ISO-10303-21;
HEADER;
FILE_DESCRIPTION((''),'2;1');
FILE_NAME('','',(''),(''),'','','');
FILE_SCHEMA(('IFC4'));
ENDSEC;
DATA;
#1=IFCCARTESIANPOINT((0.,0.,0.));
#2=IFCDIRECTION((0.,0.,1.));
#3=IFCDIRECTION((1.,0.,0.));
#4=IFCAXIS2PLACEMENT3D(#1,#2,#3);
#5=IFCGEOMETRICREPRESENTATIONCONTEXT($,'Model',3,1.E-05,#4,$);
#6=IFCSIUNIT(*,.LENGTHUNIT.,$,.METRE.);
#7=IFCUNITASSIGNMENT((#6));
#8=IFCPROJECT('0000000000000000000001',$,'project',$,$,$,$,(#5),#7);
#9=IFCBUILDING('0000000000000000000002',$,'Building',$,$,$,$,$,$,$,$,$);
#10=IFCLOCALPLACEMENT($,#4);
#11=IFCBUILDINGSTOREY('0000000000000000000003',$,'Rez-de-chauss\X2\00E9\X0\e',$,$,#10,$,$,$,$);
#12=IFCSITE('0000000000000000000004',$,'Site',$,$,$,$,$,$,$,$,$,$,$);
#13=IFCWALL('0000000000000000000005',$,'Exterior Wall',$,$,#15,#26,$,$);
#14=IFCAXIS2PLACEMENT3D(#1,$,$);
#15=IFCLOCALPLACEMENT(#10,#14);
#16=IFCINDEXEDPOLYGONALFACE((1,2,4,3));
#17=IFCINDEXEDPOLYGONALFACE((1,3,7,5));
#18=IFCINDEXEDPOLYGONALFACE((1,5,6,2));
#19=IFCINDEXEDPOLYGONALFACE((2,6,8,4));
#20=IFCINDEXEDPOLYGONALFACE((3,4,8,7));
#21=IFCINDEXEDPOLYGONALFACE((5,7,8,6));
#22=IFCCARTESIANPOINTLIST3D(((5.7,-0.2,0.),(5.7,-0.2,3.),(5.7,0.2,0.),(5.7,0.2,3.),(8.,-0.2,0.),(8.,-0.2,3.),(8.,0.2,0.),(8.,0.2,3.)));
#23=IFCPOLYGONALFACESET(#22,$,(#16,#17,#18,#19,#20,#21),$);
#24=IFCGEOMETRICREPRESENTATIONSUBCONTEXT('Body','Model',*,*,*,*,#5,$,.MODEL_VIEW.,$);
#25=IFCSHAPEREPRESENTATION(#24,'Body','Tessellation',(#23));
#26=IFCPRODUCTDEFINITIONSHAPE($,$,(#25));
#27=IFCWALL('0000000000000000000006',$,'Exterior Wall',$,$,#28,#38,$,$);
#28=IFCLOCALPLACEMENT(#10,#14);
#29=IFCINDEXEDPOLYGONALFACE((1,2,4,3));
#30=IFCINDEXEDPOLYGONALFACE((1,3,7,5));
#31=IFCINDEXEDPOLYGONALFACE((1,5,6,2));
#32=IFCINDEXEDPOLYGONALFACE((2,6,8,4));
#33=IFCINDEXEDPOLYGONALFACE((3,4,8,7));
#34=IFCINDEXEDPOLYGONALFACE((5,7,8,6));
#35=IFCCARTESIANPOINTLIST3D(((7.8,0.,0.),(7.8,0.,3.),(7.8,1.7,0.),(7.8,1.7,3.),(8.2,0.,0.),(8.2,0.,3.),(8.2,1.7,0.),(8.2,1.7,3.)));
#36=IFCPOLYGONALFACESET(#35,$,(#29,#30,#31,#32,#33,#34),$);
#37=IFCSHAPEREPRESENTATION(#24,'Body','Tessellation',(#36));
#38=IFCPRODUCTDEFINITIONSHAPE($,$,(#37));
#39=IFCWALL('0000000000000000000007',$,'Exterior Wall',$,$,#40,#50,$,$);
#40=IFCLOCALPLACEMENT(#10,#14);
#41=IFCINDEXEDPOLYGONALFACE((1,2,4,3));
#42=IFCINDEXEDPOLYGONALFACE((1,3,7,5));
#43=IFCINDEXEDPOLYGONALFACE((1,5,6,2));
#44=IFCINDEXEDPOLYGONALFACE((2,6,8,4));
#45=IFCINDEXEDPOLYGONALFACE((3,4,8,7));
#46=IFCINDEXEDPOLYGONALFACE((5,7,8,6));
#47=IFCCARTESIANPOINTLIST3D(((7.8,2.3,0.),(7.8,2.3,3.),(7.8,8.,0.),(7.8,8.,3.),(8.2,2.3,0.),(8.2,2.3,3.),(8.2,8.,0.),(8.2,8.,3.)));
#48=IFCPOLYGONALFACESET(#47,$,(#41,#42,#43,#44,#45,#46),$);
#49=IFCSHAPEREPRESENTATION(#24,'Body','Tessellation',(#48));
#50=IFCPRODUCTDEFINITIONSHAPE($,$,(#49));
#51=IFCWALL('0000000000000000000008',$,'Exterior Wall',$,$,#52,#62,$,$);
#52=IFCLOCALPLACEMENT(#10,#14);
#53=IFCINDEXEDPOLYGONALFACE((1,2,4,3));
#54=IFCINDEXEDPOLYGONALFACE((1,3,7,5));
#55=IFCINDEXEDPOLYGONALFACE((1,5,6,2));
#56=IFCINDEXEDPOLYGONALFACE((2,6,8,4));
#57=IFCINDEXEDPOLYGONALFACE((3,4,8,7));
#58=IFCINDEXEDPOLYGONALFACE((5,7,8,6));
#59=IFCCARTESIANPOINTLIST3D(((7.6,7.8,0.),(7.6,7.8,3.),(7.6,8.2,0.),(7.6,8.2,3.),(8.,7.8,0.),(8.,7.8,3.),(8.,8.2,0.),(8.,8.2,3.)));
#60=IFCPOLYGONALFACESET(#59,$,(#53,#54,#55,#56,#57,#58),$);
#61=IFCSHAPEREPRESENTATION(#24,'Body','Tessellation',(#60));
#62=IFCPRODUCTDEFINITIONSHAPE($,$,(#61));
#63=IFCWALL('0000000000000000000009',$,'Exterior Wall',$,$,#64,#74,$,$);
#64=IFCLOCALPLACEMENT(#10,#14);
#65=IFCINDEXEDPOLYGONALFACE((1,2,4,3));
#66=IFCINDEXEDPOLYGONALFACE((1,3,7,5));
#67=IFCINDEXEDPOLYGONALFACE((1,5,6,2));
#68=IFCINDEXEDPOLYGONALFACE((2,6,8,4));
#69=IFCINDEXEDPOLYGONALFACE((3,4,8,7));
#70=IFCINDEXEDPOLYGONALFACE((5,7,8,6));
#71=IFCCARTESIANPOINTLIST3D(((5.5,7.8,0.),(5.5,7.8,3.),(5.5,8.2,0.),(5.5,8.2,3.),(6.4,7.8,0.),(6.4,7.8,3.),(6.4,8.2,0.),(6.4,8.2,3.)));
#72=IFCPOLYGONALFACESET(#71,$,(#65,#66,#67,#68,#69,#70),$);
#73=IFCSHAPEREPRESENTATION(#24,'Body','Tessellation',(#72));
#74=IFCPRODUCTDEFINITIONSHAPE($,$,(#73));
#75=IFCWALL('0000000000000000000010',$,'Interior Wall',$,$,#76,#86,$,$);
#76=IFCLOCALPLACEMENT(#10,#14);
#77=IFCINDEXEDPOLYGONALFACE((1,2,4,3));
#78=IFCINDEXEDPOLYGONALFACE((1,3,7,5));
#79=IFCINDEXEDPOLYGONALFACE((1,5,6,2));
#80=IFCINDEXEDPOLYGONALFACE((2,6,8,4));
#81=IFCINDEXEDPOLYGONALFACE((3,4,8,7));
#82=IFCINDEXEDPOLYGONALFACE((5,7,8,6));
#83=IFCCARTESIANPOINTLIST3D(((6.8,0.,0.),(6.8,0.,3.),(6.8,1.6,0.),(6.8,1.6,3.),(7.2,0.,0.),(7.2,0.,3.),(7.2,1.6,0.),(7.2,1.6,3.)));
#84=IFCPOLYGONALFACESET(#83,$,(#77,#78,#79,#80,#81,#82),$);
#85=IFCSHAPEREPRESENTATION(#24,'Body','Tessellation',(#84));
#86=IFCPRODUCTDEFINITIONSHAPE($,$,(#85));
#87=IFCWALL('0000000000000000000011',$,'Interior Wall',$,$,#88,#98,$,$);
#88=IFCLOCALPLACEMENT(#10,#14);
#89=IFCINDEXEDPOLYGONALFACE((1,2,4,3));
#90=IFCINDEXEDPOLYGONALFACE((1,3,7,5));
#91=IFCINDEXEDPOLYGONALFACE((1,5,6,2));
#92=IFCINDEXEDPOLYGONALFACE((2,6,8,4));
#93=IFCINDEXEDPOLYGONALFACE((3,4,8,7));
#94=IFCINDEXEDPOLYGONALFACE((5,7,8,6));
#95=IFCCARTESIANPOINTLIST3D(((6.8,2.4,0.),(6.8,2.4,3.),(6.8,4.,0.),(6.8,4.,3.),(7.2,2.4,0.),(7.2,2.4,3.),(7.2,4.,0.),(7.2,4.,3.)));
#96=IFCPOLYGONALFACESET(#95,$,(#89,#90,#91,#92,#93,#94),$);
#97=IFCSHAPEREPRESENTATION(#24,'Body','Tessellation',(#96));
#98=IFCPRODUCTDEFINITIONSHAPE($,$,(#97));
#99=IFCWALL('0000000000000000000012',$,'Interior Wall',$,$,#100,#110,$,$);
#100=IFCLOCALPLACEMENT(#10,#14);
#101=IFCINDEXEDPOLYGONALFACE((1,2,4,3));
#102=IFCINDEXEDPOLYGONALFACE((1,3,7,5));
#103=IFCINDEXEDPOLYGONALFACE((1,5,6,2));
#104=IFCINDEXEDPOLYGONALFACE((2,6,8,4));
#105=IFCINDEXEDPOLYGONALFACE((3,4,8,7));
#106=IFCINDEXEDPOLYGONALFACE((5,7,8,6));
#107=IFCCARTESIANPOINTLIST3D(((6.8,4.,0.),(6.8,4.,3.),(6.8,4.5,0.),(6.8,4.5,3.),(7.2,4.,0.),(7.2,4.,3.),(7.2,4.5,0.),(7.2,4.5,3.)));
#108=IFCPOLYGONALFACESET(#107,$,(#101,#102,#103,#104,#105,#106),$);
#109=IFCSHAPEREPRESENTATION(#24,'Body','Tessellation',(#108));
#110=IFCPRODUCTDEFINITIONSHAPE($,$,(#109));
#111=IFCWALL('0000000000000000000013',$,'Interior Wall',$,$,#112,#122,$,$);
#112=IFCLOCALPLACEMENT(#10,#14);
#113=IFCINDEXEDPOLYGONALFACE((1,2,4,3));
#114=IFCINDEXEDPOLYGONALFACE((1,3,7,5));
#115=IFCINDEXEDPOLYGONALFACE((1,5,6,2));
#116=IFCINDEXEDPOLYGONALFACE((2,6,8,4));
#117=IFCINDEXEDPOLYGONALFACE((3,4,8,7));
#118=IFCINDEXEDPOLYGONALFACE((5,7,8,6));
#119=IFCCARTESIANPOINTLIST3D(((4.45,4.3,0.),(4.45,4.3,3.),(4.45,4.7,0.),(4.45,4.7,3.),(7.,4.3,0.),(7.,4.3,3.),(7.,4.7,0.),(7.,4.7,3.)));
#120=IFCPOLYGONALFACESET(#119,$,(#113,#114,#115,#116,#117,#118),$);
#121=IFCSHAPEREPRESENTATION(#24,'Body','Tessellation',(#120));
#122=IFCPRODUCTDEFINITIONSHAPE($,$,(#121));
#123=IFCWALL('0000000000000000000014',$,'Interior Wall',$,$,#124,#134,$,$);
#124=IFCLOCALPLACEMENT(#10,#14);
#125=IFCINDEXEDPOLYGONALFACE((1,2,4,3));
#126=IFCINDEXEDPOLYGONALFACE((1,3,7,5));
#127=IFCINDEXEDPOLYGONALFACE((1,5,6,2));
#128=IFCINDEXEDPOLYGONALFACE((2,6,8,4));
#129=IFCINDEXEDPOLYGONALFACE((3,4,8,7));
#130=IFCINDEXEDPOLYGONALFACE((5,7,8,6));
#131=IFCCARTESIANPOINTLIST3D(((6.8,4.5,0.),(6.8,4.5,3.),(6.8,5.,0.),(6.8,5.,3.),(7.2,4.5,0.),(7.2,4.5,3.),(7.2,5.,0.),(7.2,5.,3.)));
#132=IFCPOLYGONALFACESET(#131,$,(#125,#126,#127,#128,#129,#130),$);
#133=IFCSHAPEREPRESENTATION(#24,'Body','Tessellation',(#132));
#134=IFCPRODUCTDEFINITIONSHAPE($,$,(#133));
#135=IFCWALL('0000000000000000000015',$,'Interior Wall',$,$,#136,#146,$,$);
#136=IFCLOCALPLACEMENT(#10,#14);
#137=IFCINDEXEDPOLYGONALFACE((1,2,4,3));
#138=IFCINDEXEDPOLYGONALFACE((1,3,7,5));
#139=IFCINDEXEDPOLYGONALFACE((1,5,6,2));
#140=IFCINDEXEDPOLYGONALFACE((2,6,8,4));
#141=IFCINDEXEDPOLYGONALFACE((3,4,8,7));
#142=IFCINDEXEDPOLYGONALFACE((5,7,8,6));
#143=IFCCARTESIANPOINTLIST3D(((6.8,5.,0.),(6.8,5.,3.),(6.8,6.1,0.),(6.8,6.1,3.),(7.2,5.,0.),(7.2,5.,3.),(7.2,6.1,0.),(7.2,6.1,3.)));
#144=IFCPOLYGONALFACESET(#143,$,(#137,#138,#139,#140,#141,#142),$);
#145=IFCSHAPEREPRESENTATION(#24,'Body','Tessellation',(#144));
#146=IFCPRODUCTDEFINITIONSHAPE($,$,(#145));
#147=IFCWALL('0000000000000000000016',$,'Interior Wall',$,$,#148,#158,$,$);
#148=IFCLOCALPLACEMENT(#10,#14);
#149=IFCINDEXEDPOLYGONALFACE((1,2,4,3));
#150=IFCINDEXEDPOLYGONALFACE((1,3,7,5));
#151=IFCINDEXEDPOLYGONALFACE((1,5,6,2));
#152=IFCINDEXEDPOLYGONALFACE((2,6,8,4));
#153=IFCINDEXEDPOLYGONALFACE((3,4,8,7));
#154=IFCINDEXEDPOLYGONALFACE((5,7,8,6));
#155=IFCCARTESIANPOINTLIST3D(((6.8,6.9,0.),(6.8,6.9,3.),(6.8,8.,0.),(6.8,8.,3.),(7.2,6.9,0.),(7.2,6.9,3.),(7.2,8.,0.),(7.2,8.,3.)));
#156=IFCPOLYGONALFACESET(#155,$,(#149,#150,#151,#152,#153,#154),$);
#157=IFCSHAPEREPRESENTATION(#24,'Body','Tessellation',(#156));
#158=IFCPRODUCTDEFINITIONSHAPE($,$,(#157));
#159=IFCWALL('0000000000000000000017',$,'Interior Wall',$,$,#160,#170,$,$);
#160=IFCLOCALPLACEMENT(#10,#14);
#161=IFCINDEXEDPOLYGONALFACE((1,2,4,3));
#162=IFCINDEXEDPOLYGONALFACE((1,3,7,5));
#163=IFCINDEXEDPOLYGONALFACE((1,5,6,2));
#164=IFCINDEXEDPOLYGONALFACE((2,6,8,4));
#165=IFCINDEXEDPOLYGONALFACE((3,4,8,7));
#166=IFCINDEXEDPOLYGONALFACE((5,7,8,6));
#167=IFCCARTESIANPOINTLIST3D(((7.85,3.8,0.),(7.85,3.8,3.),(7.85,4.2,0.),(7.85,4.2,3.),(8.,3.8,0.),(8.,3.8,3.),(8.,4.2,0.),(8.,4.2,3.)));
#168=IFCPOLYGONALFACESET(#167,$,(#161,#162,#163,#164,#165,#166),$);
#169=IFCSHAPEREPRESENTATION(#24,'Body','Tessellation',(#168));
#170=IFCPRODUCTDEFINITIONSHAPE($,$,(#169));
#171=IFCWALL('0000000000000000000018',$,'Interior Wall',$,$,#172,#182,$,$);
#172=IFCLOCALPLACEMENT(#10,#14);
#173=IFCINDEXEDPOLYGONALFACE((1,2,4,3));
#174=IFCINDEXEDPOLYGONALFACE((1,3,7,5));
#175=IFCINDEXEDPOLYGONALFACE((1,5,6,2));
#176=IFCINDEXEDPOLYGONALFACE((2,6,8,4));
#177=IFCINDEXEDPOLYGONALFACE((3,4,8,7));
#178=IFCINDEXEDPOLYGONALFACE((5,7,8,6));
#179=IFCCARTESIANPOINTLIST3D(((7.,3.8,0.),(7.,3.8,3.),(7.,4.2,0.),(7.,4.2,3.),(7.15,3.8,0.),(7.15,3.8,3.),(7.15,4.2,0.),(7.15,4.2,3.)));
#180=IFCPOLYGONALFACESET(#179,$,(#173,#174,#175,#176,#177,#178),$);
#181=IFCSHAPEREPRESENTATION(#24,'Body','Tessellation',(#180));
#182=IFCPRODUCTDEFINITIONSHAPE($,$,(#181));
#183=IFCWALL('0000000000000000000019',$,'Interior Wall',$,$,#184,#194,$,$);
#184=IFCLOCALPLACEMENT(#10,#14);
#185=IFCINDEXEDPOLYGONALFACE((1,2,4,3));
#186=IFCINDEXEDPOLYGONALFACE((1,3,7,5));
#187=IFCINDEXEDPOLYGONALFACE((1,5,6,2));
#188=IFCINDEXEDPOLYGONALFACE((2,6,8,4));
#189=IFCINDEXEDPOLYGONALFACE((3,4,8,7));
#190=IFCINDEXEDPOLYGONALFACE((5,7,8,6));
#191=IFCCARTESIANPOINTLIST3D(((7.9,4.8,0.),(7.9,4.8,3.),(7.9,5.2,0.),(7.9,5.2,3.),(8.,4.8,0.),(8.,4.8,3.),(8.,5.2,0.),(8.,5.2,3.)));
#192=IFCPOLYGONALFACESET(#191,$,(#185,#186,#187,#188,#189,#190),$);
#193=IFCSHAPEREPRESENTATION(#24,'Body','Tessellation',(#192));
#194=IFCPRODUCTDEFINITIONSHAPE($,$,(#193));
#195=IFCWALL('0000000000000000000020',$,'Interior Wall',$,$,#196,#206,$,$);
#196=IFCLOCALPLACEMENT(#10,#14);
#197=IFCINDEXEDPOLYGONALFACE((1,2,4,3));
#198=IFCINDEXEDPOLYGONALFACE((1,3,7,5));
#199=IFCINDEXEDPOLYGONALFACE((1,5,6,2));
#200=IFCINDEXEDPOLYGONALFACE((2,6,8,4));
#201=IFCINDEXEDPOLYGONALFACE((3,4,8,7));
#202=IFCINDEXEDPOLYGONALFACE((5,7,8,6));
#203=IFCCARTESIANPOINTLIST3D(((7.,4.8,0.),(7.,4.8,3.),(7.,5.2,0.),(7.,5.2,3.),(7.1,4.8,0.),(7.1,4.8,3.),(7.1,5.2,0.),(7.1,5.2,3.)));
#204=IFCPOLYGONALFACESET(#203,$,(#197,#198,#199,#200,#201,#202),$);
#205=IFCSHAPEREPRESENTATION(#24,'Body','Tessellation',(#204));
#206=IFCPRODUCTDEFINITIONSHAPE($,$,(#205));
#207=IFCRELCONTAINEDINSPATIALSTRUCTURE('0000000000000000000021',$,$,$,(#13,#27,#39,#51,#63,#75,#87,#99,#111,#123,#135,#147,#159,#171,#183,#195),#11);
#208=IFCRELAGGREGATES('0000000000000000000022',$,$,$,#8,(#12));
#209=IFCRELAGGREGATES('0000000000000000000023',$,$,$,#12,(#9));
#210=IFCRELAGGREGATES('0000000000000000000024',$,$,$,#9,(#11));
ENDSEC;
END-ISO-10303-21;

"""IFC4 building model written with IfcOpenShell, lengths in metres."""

from ifc_helpers import new_model, si_unit, frame, origin_with_axes, place, context, subcontext, project, spatial, indexed_curve, outline, extrude, element, save


model = new_model("IFC4")

# Units and contexts
model_context = context("Model", 3, precision=1e-05, world=origin_with_axes())
body_context = subcontext(model_context, "Body", "Model", "MODEL_VIEW")
ifc_project = project(units=[si_unit("LENGTHUNIT", "METRE")], contexts=[model_context])

# Site, building, storey
site = spatial("IfcSite", under=ifc_project, Name="Site")
building = spatial("IfcBuilding", under=site, Name="Building")
storey_placement = place(None, origin_with_axes())
storey = spatial("IfcBuildingStorey", under=building, at=storey_placement, Name="Rez-de-chaussée")

# Walls
wall_1_placement = place(storey_placement, frame((5.7, 0.0, 0.0), z_axis=(0.0, 0.0, 1.0), x_axis=(1.0, 0.0, 0.0)))
element("IfcWall", 1, at=wall_1_placement, inside=storey, Name="Exterior Wall", context=body_context, shape_type="SweptSolid", body=[
    extrude(outline(indexed_curve([(0.0, 0.0), (0.0, 0.4), (2.3, 0.4), (2.3, 0.0), (0.0, 0.0)], self_intersect=False)), frame((0.0, -0.2, 0.0), z_axis=(0.0, 0.0, 1.0), x_axis=(1.0, 0.0, 0.0)), (0.0, 0.0, 1.0), 3.0),
])
wall_2_placement = place(storey_placement, frame((8.0, 0.0, 0.0), z_axis=(0.0, 0.0, 1.0), x_axis=(0.0, 1.0, 0.0)))
element("IfcWall", 2, at=wall_2_placement, inside=storey, Name="Exterior Wall", context=body_context, shape_type="SweptSolid", body=[
    extrude(outline(indexed_curve([(0.0, 0.0), (0.0, 0.4), (1.7, 0.4), (1.7, 0.0), (0.0, 0.0)], self_intersect=False)), frame((0.0, -0.2, 0.0), z_axis=(0.0, 0.0, 1.0), x_axis=(1.0, 0.0, 0.0)), (0.0, 0.0, 1.0), 3.0),
])
wall_3_placement = place(storey_placement, frame((8.0, 2.3, 0.0), z_axis=(0.0, 0.0, 1.0), x_axis=(0.0, 1.0, 0.0)))
element("IfcWall", 3, at=wall_3_placement, inside=storey, Name="Exterior Wall", context=body_context, shape_type="SweptSolid", body=[
    extrude(outline(indexed_curve([(0.0, 0.0), (0.0, 0.4), (5.7, 0.4), (5.7, 0.0), (0.0, 0.0)], self_intersect=False)), frame((0.0, -0.2, 0.0), z_axis=(0.0, 0.0, 1.0), x_axis=(1.0, 0.0, 0.0)), (0.0, 0.0, 1.0), 3.0),
])
wall_4_placement = place(storey_placement, frame((8.0, 8.0, 0.0), z_axis=(0.0, 0.0, 1.0), x_axis=(-1.0, 0.0, 0.0)))
element("IfcWall", 4, at=wall_4_placement, inside=storey, Name="Exterior Wall", context=body_context, shape_type="SweptSolid", body=[
    extrude(outline(indexed_curve([(0.0, 0.0), (0.0, 0.4), (0.4, 0.4), (0.4, 0.0), (0.0, 0.0)], self_intersect=False)), frame((0.0, -0.2, 0.0), z_axis=(0.0, 0.0, 1.0), x_axis=(1.0, 0.0, 0.0)), (0.0, 0.0, 1.0), 3.0),
])
wall_5_placement = place(storey_placement, frame((6.4, 8.0, 0.0), z_axis=(0.0, 0.0, 1.0), x_axis=(-1.0, 0.0, 0.0)))
element("IfcWall", 5, at=wall_5_placement, inside=storey, Name="Exterior Wall", context=body_context, shape_type="SweptSolid", body=[
    extrude(outline(indexed_curve([(0.0, 0.0), (0.0, 0.4), (0.9, 0.4), (0.9, 0.0), (0.0, 0.0)], self_intersect=False)), frame((0.0, -0.2, 0.0), z_axis=(0.0, 0.0, 1.0), x_axis=(1.0, 0.0, 0.0)), (0.0, 0.0, 1.0), 3.0),
])
for number, where, z_axis, x_axis, name in (
    (6, (7.0, 0.0, 0.0), (0.0, 0.0, 1.0), (0.0, 1.0, 0.0), "Interior Wall"),
    (7, (7.0, 2.4, 0.0), (0.0, 0.0, 1.0), (0.0, 1.0, 0.0), "Interior Wall"),
):
    element("IfcWall", number, at=place(storey_placement, frame(where, z_axis=z_axis, x_axis=x_axis)), inside=storey, Name=name, context=body_context, shape_type="SweptSolid", body=[
        extrude(outline(indexed_curve([(0.0, 0.0), (0.0, 0.4), (1.6, 0.4), (1.6, 0.0), (0.0, 0.0)], self_intersect=False)), frame((0.0, -0.2, 0.0), z_axis=(0.0, 0.0, 1.0), x_axis=(1.0, 0.0, 0.0)), (0.0, 0.0, 1.0), 3.0),
    ])
wall_6_placement = place(storey_placement, frame((7.0, 4.0, 0.0), z_axis=(0.0, 0.0, 1.0), x_axis=(0.0, 1.0, 0.0)))
element("IfcWall", 8, at=wall_6_placement, inside=storey, Name="Interior Wall", context=body_context, shape_type="SweptSolid", body=[
    extrude(outline(indexed_curve([(0.0, 0.0), (0.0, 0.4), (0.5, 0.4), (0.5, 0.0), (0.0, 0.0)], self_intersect=False)), frame((0.0, -0.2, 0.0), z_axis=(0.0, 0.0, 1.0), x_axis=(1.0, 0.0, 0.0)), (0.0, 0.0, 1.0), 3.0),
])
wall_7_placement = place(storey_placement, frame((7.0, 4.5, 0.0), z_axis=(0.0, 0.0, 1.0), x_axis=(-1.0, 0.0, 0.0)))
element("IfcWall", 9, at=wall_7_placement, inside=storey, Name="Interior Wall", context=body_context, shape_type="SweptSolid", body=[
    extrude(outline(indexed_curve([(0.0, 0.0), (0.0, 0.4), (2.55, 0.4), (2.55, 0.0), (0.0, 0.0)], self_intersect=False)), frame((0.0, -0.2, 0.0), z_axis=(0.0, 0.0, 1.0), x_axis=(1.0, 0.0, 0.0)), (0.0, 0.0, 1.0), 3.0),
])
wall_8_placement = place(storey_placement, frame((7.0, 4.5, 0.0), z_axis=(0.0, 0.0, 1.0), x_axis=(0.0, 1.0, 0.0)))
element("IfcWall", 10, at=wall_8_placement, inside=storey, Name="Interior Wall", context=body_context, shape_type="SweptSolid", body=[
    extrude(outline(indexed_curve([(0.0, 0.0), (0.0, 0.4), (0.5, 0.4), (0.5, 0.0), (0.0, 0.0)], self_intersect=False)), frame((0.0, -0.2, 0.0), z_axis=(0.0, 0.0, 1.0), x_axis=(1.0, 0.0, 0.0)), (0.0, 0.0, 1.0), 3.0),
])
for number, where, z_axis, x_axis, name in (
    (11, (7.0, 5.0, 0.0), (0.0, 0.0, 1.0), (0.0, 1.0, 0.0), "Interior Wall"),
    (12, (7.0, 6.9, 0.0), (0.0, 0.0, 1.0), (0.0, 1.0, 0.0), "Interior Wall"),
):
    element("IfcWall", number, at=place(storey_placement, frame(where, z_axis=z_axis, x_axis=x_axis)), inside=storey, Name=name, context=body_context, shape_type="SweptSolid", body=[
        extrude(outline(indexed_curve([(0.0, 0.0), (0.0, 0.4), (1.1, 0.4), (1.1, 0.0), (0.0, 0.0)], self_intersect=False)), frame((0.0, -0.2, 0.0), z_axis=(0.0, 0.0, 1.0), x_axis=(1.0, 0.0, 0.0)), (0.0, 0.0, 1.0), 3.0),
    ])
for number, where, z_axis, x_axis, name in (
    (13, (8.0, 4.0, 0.0), (0.0, 0.0, 1.0), (-1.0, 0.0, 0.0), "Interior Wall"),
    (14, (7.15, 4.0, 0.0), (0.0, 0.0, 1.0), (-1.0, 0.0, 0.0), "Interior Wall"),
):
    element("IfcWall", number, at=place(storey_placement, frame(where, z_axis=z_axis, x_axis=x_axis)), inside=storey, Name=name, context=body_context, shape_type="SweptSolid", body=[
        extrude(outline(indexed_curve([(0.0, 0.0), (0.0, 0.4), (0.15, 0.4), (0.15, 0.0), (0.0, 0.0)], self_intersect=False)), frame((0.0, -0.2, 0.0), z_axis=(0.0, 0.0, 1.0), x_axis=(1.0, 0.0, 0.0)), (0.0, 0.0, 1.0), 3.0),
    ])
for number, where, z_axis, x_axis, name in (
    (15, (8.0, 5.0, 0.0), (0.0, 0.0, 1.0), (-1.0, 0.0, 0.0), "Interior Wall"),
    (16, (7.1, 5.0, 0.0), (0.0, 0.0, 1.0), (-1.0, 0.0, 0.0), "Interior Wall"),
):
    element("IfcWall", number, at=place(storey_placement, frame(where, z_axis=z_axis, x_axis=x_axis)), inside=storey, Name=name, context=body_context, shape_type="SweptSolid", body=[
        extrude(outline(indexed_curve([(0.0, 0.0), (0.0, 0.4), (0.1, 0.4), (0.1, 0.0), (0.0, 0.0)], self_intersect=False)), frame((0.0, -0.2, 0.0), z_axis=(0.0, 0.0, 1.0), x_axis=(1.0, 0.0, 0.0)), (0.0, 0.0, 1.0), 3.0),
    ])

save(model, "model.ifc")
